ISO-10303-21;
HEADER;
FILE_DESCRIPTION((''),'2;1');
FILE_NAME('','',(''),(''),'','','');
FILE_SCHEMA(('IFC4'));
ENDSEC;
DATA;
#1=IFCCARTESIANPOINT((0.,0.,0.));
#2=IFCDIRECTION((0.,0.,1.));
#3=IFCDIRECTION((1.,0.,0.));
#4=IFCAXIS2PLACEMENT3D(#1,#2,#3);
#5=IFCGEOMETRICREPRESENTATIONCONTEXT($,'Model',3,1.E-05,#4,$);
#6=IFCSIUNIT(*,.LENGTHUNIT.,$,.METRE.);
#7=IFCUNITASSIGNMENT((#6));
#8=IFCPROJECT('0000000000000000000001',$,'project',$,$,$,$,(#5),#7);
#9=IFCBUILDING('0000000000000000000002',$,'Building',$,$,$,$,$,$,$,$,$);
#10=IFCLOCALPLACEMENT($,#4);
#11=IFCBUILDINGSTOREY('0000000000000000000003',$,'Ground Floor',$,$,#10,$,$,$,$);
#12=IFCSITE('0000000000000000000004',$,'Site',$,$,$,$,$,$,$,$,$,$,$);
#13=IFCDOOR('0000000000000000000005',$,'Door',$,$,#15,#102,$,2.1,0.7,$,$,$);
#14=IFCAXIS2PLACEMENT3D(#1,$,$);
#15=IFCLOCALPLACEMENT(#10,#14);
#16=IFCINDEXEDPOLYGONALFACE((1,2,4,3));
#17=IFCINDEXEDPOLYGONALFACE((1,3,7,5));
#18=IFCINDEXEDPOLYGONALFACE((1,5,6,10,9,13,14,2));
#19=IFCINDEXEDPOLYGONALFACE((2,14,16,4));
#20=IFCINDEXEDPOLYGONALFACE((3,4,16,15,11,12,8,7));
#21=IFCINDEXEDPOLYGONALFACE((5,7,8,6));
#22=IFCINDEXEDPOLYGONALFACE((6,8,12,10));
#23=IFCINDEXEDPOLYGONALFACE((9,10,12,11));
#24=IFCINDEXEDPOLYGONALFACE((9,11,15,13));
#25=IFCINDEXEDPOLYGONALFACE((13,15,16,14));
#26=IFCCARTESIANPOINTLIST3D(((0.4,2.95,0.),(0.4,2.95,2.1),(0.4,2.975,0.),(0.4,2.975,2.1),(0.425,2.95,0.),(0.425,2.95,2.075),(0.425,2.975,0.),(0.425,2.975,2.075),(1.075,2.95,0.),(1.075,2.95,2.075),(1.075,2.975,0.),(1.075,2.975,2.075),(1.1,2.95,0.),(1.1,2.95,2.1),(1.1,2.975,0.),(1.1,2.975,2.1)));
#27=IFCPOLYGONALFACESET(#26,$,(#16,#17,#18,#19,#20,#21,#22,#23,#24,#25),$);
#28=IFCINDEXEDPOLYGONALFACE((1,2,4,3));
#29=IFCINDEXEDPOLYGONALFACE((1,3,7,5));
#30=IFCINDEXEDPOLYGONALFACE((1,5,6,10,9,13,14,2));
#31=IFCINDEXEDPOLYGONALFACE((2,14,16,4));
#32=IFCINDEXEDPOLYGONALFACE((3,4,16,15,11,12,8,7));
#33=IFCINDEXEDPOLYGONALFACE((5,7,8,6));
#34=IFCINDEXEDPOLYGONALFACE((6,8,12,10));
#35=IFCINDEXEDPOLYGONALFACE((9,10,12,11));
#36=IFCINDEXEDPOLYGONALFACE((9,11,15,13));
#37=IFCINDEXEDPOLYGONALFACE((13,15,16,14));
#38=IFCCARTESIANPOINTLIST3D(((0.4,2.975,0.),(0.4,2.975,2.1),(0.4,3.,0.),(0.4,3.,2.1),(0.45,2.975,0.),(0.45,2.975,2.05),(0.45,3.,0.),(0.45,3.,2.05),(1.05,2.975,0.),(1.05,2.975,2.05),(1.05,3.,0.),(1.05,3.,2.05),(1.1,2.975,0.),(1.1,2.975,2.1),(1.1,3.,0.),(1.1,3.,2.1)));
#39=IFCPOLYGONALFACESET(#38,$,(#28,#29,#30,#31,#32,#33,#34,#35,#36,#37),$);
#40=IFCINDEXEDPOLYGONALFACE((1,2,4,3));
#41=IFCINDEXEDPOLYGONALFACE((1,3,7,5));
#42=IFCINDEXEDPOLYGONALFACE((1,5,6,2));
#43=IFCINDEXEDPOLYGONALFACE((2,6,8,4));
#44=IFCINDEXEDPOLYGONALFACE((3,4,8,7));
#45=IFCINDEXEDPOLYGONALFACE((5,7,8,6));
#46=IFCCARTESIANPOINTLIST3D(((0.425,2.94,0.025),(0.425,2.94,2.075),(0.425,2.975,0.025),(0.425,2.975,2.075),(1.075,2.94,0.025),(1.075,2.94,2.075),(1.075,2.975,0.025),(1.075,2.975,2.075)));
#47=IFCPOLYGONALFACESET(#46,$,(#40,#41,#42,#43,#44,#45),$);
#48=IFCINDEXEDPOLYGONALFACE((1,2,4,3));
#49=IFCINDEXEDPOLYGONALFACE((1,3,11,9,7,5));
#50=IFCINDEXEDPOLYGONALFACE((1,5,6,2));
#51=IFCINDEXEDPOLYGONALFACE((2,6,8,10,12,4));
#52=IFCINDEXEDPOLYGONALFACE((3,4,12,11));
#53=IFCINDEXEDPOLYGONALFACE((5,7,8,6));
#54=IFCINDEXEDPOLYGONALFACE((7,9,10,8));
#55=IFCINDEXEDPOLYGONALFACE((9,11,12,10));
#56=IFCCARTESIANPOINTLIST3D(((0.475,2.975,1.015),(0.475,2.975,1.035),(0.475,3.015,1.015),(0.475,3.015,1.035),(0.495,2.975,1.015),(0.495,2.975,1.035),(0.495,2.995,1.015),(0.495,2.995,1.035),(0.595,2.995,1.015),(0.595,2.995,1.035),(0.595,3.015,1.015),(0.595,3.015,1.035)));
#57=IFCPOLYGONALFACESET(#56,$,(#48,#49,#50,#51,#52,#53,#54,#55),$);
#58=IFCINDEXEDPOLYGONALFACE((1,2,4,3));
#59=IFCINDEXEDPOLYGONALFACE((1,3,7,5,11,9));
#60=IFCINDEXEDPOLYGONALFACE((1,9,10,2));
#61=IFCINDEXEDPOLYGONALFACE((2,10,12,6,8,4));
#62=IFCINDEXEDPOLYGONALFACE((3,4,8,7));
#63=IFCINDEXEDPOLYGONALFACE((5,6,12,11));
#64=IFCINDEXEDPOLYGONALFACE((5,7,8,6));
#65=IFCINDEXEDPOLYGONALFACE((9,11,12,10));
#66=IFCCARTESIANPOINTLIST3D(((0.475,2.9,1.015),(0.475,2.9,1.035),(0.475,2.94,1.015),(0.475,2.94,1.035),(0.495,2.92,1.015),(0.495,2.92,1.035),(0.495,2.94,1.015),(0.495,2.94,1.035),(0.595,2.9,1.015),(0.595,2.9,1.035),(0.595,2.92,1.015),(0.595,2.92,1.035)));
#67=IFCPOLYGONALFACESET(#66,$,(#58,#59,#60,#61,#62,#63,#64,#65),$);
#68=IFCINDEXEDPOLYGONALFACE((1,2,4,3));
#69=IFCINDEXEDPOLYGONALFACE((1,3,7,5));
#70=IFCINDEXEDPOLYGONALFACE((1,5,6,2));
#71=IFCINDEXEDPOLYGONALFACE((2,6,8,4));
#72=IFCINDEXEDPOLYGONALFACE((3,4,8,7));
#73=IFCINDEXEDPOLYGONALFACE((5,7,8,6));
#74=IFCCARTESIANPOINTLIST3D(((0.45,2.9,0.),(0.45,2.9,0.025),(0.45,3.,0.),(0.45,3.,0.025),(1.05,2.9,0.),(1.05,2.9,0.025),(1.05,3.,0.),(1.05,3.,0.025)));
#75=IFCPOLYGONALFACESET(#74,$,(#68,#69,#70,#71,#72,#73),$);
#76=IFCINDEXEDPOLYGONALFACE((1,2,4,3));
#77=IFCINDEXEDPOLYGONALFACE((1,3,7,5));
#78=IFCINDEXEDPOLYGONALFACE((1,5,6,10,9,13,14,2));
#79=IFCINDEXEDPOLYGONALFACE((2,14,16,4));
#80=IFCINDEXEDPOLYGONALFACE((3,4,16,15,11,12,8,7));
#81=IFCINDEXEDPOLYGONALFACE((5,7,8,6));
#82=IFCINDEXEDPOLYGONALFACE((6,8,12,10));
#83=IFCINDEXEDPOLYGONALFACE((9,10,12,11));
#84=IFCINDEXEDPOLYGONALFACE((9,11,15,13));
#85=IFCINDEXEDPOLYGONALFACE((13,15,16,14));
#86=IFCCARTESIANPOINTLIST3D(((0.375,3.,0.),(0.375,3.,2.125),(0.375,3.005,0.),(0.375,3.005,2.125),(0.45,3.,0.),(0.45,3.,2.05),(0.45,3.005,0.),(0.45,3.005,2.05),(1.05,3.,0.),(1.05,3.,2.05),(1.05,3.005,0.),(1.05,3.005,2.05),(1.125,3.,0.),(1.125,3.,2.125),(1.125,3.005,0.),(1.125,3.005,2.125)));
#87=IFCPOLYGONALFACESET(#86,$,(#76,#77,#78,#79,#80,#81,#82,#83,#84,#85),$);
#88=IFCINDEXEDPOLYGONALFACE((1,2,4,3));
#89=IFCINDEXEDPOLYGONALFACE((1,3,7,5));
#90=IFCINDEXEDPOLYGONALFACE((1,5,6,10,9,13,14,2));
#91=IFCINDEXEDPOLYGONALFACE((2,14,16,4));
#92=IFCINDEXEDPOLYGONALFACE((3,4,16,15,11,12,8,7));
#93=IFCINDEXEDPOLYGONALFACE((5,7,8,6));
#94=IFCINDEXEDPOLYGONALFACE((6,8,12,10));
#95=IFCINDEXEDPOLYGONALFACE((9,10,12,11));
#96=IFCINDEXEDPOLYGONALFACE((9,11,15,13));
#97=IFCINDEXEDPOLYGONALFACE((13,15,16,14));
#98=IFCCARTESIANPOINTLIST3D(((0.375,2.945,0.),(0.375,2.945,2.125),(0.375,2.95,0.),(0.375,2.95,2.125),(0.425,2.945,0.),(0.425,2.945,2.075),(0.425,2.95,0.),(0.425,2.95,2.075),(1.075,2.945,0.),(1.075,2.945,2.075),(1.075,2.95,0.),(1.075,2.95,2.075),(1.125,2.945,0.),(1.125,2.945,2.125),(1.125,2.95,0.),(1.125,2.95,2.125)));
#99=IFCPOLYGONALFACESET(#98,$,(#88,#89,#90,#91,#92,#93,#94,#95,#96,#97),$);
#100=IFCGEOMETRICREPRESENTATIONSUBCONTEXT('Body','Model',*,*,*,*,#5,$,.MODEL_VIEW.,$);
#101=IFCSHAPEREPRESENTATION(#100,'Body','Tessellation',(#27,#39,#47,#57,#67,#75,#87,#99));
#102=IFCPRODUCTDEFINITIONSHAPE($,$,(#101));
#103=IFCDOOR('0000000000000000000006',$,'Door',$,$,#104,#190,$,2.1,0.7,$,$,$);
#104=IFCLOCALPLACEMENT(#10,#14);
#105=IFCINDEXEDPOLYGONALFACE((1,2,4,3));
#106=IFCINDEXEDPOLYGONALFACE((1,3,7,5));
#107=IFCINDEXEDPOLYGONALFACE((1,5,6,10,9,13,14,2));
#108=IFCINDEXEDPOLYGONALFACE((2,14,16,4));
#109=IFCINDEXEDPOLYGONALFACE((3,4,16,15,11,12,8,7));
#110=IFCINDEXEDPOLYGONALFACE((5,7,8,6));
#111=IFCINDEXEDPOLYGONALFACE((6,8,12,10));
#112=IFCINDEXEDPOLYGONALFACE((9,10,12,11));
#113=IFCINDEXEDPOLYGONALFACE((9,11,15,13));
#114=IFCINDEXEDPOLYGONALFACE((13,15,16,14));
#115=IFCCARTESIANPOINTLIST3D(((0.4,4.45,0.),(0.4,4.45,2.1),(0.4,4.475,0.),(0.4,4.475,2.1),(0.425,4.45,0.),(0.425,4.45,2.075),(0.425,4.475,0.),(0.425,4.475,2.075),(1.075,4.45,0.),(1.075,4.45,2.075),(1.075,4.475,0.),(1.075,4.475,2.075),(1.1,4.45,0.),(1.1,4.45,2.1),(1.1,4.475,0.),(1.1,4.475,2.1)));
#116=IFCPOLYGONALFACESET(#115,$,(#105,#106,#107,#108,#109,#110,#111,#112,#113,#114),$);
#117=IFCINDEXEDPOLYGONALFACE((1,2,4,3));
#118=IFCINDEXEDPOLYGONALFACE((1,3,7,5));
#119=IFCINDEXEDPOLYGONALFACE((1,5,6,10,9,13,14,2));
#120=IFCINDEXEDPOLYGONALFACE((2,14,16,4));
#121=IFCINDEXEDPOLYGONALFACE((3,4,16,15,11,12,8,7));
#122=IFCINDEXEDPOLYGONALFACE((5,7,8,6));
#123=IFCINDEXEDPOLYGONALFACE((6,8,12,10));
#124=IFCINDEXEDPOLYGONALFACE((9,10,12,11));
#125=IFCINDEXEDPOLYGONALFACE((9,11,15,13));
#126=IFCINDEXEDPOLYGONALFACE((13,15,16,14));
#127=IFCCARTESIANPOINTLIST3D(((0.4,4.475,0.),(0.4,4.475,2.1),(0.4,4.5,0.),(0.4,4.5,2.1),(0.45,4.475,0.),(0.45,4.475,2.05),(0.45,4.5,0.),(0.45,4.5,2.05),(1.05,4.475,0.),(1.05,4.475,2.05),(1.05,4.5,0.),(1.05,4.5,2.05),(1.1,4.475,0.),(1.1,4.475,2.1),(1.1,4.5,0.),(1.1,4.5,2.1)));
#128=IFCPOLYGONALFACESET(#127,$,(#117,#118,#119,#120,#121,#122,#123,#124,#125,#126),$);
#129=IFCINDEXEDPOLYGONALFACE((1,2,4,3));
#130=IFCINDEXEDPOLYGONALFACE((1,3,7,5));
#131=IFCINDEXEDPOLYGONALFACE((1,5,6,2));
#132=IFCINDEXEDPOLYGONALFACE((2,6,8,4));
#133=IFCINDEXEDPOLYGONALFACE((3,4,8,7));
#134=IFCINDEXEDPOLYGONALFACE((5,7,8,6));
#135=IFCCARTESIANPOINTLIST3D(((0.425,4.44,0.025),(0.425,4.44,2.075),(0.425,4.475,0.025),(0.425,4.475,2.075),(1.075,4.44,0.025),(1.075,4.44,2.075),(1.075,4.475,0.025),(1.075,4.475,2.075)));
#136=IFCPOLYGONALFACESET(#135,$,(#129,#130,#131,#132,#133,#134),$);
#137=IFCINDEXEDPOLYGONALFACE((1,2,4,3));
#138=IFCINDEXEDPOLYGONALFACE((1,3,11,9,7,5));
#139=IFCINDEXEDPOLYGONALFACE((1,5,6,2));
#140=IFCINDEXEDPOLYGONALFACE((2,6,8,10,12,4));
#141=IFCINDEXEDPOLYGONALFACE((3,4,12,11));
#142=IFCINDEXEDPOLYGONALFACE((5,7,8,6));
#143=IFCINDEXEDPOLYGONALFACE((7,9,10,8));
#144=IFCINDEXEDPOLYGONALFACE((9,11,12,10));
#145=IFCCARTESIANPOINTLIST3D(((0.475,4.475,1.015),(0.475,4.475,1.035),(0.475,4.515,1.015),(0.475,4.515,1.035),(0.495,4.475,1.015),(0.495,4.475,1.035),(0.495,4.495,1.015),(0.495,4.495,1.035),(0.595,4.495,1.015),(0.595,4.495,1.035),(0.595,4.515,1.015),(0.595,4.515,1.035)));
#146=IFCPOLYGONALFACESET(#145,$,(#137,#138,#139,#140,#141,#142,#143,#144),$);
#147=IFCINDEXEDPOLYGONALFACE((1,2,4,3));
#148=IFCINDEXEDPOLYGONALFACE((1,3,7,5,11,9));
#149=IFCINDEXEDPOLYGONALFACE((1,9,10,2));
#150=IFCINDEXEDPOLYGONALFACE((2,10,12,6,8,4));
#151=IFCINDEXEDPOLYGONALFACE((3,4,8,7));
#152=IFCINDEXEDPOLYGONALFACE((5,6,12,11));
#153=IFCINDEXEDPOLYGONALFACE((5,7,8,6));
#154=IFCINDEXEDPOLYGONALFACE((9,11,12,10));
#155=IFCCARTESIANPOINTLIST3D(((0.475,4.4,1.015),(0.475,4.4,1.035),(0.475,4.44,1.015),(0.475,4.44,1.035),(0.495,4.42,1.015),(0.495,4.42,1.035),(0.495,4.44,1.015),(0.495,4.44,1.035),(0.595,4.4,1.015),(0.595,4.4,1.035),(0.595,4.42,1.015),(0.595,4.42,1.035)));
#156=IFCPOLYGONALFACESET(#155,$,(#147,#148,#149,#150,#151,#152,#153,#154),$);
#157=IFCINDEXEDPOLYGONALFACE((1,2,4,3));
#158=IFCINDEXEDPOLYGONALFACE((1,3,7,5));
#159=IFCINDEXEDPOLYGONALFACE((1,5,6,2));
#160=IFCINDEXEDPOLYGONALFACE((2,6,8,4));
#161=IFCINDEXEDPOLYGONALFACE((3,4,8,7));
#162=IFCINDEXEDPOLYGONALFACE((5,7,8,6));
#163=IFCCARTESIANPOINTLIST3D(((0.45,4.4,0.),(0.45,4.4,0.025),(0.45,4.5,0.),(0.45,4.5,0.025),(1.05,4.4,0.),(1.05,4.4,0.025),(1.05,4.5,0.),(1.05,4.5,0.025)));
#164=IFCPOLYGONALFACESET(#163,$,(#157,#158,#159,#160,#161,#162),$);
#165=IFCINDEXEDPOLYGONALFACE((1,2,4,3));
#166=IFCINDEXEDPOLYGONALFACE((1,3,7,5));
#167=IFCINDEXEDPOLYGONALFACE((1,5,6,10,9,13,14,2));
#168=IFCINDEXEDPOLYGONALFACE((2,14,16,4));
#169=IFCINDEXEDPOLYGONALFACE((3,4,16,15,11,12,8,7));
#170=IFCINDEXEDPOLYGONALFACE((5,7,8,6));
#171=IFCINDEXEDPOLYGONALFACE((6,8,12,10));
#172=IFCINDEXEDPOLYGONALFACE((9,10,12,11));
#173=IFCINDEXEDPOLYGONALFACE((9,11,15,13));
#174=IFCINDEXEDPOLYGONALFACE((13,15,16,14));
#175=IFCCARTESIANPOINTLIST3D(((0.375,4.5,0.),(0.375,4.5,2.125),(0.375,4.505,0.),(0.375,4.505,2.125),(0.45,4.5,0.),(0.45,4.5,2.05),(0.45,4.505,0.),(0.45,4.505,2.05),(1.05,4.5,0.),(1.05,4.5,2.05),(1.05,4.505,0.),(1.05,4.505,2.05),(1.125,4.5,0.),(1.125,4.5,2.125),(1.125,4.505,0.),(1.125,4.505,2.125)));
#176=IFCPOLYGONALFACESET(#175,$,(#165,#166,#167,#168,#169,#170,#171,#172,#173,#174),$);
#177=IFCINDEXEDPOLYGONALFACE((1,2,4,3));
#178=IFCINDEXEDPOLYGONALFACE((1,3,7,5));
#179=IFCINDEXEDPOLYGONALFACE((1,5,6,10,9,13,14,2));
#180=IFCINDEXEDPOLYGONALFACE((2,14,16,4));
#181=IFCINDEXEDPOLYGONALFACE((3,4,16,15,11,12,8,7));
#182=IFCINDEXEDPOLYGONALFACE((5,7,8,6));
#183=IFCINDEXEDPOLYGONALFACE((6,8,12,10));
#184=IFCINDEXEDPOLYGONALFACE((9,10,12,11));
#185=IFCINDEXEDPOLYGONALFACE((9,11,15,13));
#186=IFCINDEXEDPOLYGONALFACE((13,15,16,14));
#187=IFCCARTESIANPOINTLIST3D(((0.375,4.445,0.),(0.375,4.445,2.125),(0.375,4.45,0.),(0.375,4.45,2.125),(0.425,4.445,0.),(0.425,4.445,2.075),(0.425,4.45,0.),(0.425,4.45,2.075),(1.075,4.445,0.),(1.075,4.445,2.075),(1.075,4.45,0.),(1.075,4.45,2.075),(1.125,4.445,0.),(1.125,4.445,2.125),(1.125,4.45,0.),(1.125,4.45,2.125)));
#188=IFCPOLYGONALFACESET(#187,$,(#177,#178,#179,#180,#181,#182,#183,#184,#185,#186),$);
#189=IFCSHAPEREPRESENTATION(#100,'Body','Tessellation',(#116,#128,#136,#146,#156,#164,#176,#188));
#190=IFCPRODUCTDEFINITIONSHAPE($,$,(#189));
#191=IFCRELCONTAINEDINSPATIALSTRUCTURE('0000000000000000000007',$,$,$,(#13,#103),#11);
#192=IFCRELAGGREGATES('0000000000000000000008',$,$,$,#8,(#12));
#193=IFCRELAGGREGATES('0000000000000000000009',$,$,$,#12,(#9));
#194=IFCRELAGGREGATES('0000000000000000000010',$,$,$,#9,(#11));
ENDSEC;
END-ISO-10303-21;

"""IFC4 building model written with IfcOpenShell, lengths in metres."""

from ifc_helpers import new_model, si_unit, frame, origin_with_axes, place, context, subcontext, project, spatial, line, indexed_curve, outline, extrude, element, save


model = new_model("IFC4")

# Units and contexts
model_context = context("Model", 3, precision=1e-05, world=origin_with_axes())
body_context = subcontext(model_context, "Body", "Model", "MODEL_VIEW")
ifc_project = project(units=[si_unit("LENGTHUNIT", "METRE")], contexts=[model_context])

# Site, building, storey
site = spatial("IfcSite", under=ifc_project, Name="Site")
building = spatial("IfcBuilding", under=site, Name="Building")
storey_placement = place(None, origin_with_axes())
storey = spatial("IfcBuildingStorey", under=building, at=storey_placement, Name="Ground Floor")

# Doors
door_1_placement = place(storey_placement, frame((1.1, 3.0, 0.0), z_axis=(0.0, 0.0, 1.0), x_axis=(-1.0, 0.0, 0.0)))
element("IfcDoor", 1, at=door_1_placement, inside=storey, Name="Door", OverallHeight=2.1, OverallWidth=0.7, context=body_context, shape_type="SweptSolid", body=[
    extrude(outline(indexed_curve([(0.0, 0.0), (0.0, 2.1), (0.7, 2.1), (0.7, 0.0), (0.675, 0.0), (0.675, 2.075), (0.025, 2.075), (0.025, 0.0)], segments=[line(1, 2, 3, 4, 5, 6, 7, 8, 1)])), frame((0.0, 0.025, 0.0), z_axis=(0.0, -1.0, 0.0), x_axis=(1.0, 0.0, 0.0)), (0.0, 0.0, -1.0), 0.025),
    extrude(outline(indexed_curve([(0.0, 0.0), (0.0, 2.1), (0.7, 2.1), (0.7, 0.0), (0.65, 0.0), (0.65, 2.05), (0.05, 2.05), (0.05, 0.0)], segments=[line(1, 2, 3, 4, 5, 6, 7, 8, 1)])), frame((0.0, 0.0, 0.0), z_axis=(0.0, -1.0, 0.0), x_axis=(1.0, 0.0, 0.0)), (0.0, 0.0, -1.0), 0.025),
    extrude(outline(indexed_curve([(0.0, 0.0), (0.65, 0.0), (0.65, 0.035), (0.0, 0.035)], segments=[line(1, 2, 3, 4, 1)])), frame((0.025, 0.025, 0.025), z_axis=(0.0, 0.0, 1.0), x_axis=(1.0, 0.0, 0.0)), (0.0, 0.0, 1.0), 2.05),
    extrude(outline(indexed_curve([(0.0, 0.0), (0.0, -0.04), (-0.12, -0.04), (-0.12, -0.02), (-0.02, -0.02), (-0.02, 0.0)], segments=[line(1, 2, 3, 4, 5, 6, 1)])), frame((0.625, 0.025, 1.015), z_axis=(0.0, 0.0, 1.0), x_axis=(1.0, 0.0, 0.0)), (0.0, 0.0, 1.0), 0.02),
    extrude(outline(indexed_curve([(0.0, 0.0), (0.0, 0.04), (-0.12, 0.04), (-0.12, 0.02), (-0.02, 0.02), (-0.02, 0.0)], segments=[line(1, 2, 3, 4, 5, 6, 1)])), frame((0.625, 0.06, 1.015), z_axis=(0.0, 0.0, 1.0), x_axis=(1.0, 0.0, 0.0)), (0.0, 0.0, 1.0), 0.02),
    extrude(outline(indexed_curve([(0.0, 0.0), (0.6, 0.0), (0.6, 0.1), (0.0, 0.1)], segments=[line(1, 2, 3, 4, 1)])), frame((0.05, 0.0, 0.0), z_axis=(0.0, 0.0, 1.0), x_axis=(1.0, 0.0, 0.0)), (0.0, 0.0, 1.0), 0.025),
    extrude(outline(indexed_curve([(0.0, 0.0), (0.0, 2.125), (0.75, 2.125), (0.75, 0.0), (0.675, 0.0), (0.675, 2.05), (0.075, 2.05), (0.075, 0.0)], segments=[line(1, 2, 3, 4, 5, 6, 7, 8, 1)])), frame((-0.025, -0.005, 0.0), z_axis=(0.0, -1.0, 0.0), x_axis=(1.0, 0.0, 0.0)), (0.0, 0.0, -1.0), 0.005),
    extrude(outline(indexed_curve([(0.0, 0.0), (0.0, 2.125), (0.75, 2.125), (0.75, 0.0), (0.7, 0.0), (0.7, 2.075), (0.05, 2.075), (0.05, 0.0)], segments=[line(1, 2, 3, 4, 5, 6, 7, 8, 1)])), frame((-0.025, 0.05, 0.0), z_axis=(0.0, -1.0, 0.0), x_axis=(1.0, 0.0, 0.0)), (0.0, 0.0, -1.0), 0.005),
])
door_2_placement = place(storey_placement, frame((1.1, 4.5, 0.0), z_axis=(0.0, 0.0, 1.0), x_axis=(-1.0, 0.0, 0.0)))
element("IfcDoor", 2, at=door_2_placement, inside=storey, Name="Door", OverallHeight=2.1, OverallWidth=0.7, context=body_context, shape_type="SweptSolid", body=[
    extrude(outline(indexed_curve([(0.0, 0.0), (0.0, 2.1), (0.7, 2.1), (0.7, 0.0), (0.675, 0.0), (0.675, 2.075), (0.025, 2.075), (0.025, 0.0)], segments=[line(1, 2, 3, 4, 5, 6, 7, 8, 1)])), frame((0.0, 0.025, 0.0), z_axis=(0.0, -1.0, 0.0), x_axis=(1.0, 0.0, 0.0)), (0.0, 0.0, -1.0), 0.025),
    extrude(outline(indexed_curve([(0.0, 0.0), (0.0, 2.1), (0.7, 2.1), (0.7, 0.0), (0.65, 0.0), (0.65, 2.05), (0.05, 2.05), (0.05, 0.0)], segments=[line(1, 2, 3, 4, 5, 6, 7, 8, 1)])), frame((0.0, 0.0, 0.0), z_axis=(0.0, -1.0, 0.0), x_axis=(1.0, 0.0, 0.0)), (0.0, 0.0, -1.0), 0.025),
    extrude(outline(indexed_curve([(0.0, 0.0), (0.65, 0.0), (0.65, 0.035), (0.0, 0.035)], segments=[line(1, 2, 3, 4, 1)])), frame((0.025, 0.025, 0.025), z_axis=(0.0, 0.0, 1.0), x_axis=(1.0, 0.0, 0.0)), (0.0, 0.0, 1.0), 2.05),
    extrude(outline(indexed_curve([(0.0, 0.0), (0.0, -0.04), (-0.12, -0.04), (-0.12, -0.02), (-0.02, -0.02), (-0.02, 0.0)], segments=[line(1, 2, 3, 4, 5, 6, 1)])), frame((0.625, 0.025, 1.015), z_axis=(0.0, 0.0, 1.0), x_axis=(1.0, 0.0, 0.0)), (0.0, 0.0, 1.0), 0.02),
    extrude(outline(indexed_curve([(0.0, 0.0), (0.0, 0.04), (-0.12, 0.04), (-0.12, 0.02), (-0.02, 0.02), (-0.02, 0.0)], segments=[line(1, 2, 3, 4, 5, 6, 1)])), frame((0.625, 0.06, 1.015), z_axis=(0.0, 0.0, 1.0), x_axis=(1.0, 0.0, 0.0)), (0.0, 0.0, 1.0), 0.02),
    extrude(outline(indexed_curve([(0.0, 0.0), (0.6, 0.0), (0.6, 0.1), (0.0, 0.1)], segments=[line(1, 2, 3, 4, 1)])), frame((0.05, 0.0, 0.0), z_axis=(0.0, 0.0, 1.0), x_axis=(1.0, 0.0, 0.0)), (0.0, 0.0, 1.0), 0.025),
    extrude(outline(indexed_curve([(0.0, 0.0), (0.0, 2.125), (0.75, 2.125), (0.75, 0.0), (0.675, 0.0), (0.675, 2.05), (0.075, 2.05), (0.075, 0.0)], segments=[line(1, 2, 3, 4, 5, 6, 7, 8, 1)])), frame((-0.025, -0.005, 0.0), z_axis=(0.0, -1.0, 0.0), x_axis=(1.0, 0.0, 0.0)), (0.0, 0.0, -1.0), 0.005),
    extrude(outline(indexed_curve([(0.0, 0.0), (0.0, 2.125), (0.75, 2.125), (0.75, 0.0), (0.7, 0.0), (0.7, 2.075), (0.05, 2.075), (0.05, 0.0)], segments=[line(1, 2, 3, 4, 5, 6, 7, 8, 1)])), frame((-0.025, 0.05, 0.0), z_axis=(0.0, -1.0, 0.0), x_axis=(1.0, 0.0, 0.0)), (0.0, 0.0, -1.0), 0.005),
])

save(model, "model.ifc")
